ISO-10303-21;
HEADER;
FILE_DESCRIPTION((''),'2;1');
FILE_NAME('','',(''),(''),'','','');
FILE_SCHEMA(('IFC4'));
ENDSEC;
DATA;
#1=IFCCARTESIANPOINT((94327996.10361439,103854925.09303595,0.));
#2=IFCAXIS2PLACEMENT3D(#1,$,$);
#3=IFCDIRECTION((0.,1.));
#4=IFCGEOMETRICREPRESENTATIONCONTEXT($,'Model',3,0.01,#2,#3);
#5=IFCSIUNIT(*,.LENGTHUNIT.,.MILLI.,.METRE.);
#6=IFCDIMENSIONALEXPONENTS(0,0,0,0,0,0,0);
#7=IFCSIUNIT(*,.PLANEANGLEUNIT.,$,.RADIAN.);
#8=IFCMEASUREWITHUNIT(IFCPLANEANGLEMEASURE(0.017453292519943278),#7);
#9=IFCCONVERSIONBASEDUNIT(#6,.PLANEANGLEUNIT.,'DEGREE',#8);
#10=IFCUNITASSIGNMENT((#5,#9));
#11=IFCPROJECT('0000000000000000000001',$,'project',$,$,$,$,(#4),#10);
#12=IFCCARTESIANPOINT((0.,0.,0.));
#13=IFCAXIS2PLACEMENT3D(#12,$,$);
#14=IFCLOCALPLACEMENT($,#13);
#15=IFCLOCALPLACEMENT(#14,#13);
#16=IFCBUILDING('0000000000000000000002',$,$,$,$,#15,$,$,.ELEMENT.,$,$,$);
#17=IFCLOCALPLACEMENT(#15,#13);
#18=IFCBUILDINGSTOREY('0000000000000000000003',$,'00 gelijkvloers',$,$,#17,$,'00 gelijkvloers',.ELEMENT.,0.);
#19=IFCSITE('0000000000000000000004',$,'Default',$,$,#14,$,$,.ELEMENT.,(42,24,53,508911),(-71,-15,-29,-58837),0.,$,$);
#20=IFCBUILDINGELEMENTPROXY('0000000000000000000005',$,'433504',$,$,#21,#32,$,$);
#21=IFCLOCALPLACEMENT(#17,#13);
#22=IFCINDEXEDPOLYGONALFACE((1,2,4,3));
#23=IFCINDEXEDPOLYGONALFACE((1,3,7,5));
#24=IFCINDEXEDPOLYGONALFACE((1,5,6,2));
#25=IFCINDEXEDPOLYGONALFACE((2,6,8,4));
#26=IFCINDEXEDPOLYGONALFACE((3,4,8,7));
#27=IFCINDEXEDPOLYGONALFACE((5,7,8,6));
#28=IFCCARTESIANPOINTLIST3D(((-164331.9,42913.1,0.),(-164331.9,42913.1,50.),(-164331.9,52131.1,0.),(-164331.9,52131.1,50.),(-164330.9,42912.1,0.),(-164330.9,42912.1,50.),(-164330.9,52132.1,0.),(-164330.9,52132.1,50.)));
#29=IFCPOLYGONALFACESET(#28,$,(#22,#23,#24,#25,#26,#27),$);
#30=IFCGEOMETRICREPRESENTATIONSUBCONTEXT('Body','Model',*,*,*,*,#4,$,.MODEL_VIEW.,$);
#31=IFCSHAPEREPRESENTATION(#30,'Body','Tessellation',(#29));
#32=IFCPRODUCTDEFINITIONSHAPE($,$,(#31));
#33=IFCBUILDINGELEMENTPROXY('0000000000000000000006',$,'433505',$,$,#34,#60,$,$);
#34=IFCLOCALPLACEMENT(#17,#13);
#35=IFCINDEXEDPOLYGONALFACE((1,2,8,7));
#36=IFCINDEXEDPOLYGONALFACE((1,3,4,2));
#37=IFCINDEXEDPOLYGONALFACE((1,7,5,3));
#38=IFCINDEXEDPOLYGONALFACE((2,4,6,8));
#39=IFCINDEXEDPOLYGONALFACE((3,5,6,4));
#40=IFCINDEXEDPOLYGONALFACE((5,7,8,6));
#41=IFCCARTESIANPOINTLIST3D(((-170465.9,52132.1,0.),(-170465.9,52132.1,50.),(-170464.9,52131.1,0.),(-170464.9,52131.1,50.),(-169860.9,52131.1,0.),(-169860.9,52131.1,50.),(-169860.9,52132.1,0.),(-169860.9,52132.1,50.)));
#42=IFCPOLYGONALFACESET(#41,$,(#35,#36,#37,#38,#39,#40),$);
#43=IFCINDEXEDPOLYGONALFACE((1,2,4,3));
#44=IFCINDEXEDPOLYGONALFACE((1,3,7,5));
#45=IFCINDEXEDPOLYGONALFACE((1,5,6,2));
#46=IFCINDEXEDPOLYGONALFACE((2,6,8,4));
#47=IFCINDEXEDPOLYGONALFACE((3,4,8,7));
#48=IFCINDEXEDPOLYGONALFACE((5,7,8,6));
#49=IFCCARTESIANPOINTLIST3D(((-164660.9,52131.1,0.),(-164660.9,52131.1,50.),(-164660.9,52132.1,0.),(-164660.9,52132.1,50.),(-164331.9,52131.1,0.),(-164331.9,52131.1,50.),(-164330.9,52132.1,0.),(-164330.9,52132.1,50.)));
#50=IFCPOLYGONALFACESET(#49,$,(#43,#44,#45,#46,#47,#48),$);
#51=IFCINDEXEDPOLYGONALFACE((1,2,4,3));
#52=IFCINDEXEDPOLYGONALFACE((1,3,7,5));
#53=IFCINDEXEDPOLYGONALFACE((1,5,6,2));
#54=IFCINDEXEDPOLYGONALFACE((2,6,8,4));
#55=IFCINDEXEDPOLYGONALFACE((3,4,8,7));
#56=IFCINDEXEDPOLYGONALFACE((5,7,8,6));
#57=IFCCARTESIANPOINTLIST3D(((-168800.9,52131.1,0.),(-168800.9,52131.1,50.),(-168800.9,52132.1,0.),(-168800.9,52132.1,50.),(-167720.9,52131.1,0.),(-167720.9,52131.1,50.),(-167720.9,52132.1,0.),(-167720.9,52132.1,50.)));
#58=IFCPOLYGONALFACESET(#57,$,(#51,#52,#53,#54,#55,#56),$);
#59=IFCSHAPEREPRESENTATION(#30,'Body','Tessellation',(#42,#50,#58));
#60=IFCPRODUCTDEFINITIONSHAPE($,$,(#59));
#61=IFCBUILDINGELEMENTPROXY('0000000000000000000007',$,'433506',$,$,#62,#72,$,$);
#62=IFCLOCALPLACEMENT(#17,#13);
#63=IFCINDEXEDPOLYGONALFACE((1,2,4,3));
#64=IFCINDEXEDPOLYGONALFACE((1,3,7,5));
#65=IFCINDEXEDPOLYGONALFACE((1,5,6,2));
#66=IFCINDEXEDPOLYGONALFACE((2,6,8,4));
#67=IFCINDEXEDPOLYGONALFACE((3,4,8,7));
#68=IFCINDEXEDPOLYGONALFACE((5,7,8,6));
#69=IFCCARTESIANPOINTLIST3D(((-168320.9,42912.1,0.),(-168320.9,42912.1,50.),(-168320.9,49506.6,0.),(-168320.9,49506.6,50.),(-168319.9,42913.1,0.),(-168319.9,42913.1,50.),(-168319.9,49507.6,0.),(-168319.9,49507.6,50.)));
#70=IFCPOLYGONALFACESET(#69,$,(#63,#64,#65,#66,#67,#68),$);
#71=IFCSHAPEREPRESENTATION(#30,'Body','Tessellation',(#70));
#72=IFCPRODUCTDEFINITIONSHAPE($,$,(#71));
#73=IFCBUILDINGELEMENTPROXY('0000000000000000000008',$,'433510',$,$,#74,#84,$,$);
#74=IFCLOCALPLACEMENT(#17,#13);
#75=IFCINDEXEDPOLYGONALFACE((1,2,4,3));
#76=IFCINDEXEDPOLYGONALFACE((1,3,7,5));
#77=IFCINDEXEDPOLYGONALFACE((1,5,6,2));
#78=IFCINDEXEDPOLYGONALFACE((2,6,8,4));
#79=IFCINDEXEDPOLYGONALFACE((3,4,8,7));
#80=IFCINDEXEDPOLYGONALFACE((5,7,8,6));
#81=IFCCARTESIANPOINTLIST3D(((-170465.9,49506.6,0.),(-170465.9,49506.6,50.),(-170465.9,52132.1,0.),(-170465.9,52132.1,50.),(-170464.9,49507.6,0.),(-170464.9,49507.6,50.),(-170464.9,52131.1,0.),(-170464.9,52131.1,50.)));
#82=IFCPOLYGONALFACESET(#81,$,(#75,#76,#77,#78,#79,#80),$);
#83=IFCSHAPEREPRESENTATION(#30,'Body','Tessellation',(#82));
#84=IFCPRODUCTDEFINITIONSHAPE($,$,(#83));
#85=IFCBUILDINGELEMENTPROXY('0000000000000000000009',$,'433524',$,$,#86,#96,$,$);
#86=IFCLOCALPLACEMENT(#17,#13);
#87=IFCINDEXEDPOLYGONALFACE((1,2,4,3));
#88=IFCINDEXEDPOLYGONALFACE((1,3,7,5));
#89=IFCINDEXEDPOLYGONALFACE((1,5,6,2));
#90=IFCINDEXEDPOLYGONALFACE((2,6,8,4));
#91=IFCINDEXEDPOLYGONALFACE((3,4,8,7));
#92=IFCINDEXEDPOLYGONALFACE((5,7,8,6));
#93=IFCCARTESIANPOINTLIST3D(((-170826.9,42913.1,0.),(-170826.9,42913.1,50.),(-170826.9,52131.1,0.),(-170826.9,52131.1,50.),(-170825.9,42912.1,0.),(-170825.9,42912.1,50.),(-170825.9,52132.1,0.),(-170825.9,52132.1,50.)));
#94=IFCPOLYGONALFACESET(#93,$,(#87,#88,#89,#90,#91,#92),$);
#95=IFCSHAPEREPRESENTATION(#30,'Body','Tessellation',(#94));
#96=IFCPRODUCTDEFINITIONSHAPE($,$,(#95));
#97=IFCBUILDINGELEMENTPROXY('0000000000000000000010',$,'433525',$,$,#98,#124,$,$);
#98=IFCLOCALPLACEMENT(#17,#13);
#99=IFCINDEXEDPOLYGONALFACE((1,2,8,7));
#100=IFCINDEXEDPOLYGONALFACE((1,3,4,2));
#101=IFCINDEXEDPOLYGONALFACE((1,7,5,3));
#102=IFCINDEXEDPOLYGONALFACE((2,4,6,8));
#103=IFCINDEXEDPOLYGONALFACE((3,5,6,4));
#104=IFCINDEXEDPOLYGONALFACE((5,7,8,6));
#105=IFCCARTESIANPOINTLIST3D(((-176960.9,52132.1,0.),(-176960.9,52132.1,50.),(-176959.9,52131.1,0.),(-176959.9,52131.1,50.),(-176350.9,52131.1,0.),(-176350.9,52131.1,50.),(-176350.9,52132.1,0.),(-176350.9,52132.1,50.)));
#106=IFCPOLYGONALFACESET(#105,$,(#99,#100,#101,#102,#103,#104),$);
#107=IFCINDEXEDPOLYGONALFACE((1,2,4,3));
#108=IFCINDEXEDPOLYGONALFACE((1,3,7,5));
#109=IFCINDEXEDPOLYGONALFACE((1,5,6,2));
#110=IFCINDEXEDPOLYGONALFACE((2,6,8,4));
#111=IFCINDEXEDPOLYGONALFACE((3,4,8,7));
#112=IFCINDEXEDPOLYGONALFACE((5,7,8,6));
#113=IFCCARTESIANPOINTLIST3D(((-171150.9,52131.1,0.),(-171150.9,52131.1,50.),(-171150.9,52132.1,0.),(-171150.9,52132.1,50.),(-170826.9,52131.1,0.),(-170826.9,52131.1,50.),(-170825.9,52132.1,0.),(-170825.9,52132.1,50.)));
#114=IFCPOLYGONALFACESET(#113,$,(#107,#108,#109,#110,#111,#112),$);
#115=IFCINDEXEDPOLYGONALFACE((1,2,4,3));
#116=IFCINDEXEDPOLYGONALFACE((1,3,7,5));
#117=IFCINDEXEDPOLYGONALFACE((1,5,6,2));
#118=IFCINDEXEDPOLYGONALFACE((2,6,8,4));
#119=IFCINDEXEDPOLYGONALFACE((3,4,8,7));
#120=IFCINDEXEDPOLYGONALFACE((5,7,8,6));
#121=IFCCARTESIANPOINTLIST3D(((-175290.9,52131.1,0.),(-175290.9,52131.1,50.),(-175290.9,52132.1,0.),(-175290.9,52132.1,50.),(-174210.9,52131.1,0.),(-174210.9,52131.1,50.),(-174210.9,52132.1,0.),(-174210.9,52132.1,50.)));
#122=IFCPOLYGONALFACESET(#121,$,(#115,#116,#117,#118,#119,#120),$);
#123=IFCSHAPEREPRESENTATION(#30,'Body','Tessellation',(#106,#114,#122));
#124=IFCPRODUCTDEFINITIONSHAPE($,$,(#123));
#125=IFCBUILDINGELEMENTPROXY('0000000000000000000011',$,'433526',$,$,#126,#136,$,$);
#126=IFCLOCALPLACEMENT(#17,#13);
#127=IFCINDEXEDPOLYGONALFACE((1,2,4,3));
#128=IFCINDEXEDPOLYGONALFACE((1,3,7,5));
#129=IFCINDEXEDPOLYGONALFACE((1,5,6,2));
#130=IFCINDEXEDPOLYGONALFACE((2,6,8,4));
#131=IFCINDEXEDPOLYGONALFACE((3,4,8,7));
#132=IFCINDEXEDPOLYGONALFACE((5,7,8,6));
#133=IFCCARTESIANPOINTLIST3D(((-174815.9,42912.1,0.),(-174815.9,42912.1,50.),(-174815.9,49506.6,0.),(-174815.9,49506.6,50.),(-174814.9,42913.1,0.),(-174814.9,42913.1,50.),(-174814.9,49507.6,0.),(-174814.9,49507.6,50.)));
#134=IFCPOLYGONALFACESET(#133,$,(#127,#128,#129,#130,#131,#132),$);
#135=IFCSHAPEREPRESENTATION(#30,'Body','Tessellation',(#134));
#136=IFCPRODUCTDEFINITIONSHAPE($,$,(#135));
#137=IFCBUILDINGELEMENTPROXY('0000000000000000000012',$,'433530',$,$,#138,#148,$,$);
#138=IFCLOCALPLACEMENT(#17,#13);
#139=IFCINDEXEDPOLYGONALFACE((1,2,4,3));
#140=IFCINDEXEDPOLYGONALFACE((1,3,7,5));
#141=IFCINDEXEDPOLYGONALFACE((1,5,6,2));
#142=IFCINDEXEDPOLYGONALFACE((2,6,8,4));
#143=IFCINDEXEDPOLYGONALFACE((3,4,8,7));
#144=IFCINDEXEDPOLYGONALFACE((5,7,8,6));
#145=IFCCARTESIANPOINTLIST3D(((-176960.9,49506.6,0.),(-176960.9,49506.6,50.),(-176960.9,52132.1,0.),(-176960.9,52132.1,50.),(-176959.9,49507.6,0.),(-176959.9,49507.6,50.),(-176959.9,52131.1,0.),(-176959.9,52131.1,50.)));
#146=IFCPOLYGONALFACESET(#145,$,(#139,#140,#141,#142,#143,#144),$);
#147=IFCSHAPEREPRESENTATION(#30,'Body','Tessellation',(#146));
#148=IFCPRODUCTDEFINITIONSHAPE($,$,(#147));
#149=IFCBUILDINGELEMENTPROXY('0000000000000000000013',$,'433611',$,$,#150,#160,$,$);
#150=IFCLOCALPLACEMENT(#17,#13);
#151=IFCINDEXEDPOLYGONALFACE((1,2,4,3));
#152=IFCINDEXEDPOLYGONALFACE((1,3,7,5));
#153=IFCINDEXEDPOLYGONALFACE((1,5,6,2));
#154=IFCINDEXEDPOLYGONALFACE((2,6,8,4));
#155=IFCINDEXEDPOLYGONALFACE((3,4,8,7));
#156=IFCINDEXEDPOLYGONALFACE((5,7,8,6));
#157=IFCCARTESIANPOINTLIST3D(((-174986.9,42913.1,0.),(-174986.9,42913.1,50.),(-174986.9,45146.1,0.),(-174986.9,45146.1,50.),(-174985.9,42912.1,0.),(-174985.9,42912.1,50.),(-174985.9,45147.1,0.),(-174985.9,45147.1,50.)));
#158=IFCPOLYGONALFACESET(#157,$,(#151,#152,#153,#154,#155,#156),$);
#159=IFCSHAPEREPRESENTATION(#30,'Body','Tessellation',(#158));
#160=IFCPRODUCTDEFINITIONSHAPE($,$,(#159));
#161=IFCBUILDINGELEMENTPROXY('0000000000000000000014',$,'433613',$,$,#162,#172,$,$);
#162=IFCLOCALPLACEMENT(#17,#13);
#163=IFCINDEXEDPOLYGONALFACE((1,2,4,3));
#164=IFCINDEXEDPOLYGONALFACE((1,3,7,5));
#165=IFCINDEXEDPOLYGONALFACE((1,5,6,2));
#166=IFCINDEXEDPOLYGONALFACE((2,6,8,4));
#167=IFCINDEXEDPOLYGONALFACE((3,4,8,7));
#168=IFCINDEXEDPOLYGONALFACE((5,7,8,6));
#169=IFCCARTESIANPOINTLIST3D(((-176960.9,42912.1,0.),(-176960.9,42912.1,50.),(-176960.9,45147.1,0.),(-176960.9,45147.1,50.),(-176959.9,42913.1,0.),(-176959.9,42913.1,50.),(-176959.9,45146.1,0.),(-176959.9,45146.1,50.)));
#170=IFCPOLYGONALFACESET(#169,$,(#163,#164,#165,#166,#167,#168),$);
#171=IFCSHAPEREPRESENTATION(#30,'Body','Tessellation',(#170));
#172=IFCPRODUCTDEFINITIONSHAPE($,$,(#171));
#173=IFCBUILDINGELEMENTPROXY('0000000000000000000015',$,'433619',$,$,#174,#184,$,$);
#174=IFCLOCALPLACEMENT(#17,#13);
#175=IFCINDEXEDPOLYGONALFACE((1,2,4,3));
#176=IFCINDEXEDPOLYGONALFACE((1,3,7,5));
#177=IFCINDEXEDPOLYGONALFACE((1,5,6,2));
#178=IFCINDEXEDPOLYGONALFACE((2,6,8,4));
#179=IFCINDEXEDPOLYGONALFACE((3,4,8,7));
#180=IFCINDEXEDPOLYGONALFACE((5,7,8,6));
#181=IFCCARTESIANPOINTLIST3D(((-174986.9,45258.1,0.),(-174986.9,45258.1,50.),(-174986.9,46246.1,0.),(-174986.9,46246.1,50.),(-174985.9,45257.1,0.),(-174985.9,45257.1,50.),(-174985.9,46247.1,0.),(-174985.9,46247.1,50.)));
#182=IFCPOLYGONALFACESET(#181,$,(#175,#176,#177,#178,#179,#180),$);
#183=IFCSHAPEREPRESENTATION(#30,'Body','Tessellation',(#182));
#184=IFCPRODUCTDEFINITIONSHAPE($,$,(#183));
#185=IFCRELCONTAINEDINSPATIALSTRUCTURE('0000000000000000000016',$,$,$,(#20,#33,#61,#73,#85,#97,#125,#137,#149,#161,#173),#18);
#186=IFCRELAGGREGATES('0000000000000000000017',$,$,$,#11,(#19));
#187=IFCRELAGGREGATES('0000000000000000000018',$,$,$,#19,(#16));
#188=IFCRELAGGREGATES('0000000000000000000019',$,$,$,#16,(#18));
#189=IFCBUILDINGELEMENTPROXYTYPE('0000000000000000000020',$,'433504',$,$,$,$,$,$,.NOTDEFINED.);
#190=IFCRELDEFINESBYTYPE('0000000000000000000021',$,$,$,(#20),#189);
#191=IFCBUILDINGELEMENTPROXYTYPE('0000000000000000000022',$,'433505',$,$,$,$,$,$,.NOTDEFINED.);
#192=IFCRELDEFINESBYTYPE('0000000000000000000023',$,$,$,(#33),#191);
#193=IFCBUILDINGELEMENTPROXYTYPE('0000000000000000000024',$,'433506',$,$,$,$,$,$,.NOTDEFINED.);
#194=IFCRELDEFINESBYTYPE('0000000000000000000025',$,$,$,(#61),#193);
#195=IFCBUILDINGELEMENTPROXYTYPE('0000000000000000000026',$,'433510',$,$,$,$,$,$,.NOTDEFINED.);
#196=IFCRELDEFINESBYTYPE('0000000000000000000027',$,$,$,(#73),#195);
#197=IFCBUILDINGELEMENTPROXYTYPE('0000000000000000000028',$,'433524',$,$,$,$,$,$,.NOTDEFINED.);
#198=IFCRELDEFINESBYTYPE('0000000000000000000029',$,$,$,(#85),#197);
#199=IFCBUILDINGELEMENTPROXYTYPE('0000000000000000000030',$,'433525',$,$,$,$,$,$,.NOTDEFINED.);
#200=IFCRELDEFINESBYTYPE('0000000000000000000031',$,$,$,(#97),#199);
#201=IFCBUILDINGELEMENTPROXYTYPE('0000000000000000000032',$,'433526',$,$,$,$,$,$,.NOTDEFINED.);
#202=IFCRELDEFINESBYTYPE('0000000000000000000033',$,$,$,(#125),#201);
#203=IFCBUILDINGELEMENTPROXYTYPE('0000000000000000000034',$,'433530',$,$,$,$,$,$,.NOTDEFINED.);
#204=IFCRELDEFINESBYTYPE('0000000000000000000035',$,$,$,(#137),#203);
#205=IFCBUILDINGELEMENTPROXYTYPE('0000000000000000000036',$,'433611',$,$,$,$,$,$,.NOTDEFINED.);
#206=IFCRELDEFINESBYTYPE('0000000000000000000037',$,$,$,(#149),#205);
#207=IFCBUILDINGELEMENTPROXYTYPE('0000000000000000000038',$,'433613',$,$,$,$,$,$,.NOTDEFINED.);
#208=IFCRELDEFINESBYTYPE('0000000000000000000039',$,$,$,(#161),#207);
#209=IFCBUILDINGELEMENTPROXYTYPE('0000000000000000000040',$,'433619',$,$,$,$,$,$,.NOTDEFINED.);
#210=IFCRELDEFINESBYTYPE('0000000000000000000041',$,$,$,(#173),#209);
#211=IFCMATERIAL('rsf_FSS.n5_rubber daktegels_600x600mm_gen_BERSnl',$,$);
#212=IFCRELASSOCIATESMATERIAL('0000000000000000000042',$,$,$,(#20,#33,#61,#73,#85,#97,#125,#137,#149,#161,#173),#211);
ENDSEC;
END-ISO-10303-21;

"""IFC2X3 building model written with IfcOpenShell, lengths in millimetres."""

from ifc_helpers import new_model, entity, si_unit, converted_unit, direction, frame, frame_2d, origin, origin_2d_with_axis, place, context, subcontext, project, spatial, polyline, rectangle, outline, extrude, material, type_object, element, save


model = new_model("IFC2X3")

# Units and contexts
model_context = context("Model", 3, precision=0.01, world=frame((94327996.10361439, 103854925.09303595, 0.0)), true_north=direction((0.0, 1.0)))
body_context = subcontext(model_context, "Body", "Model", "MODEL_VIEW")
ifc_project = project(units=[si_unit("LENGTHUNIT", "METRE", prefix="MILLI"), converted_unit("PLANEANGLEUNIT", "DEGREE", entity("IfcPlaneAngleMeasure", 0.017453292519943278), si_unit("PLANEANGLEUNIT", "RADIAN"), dimensions=[0, 0, 0, 0, 0, 0, 0])], contexts=[model_context])

# Site, building, storey
site_placement = place(None, origin())
site = spatial("IfcSite", under=ifc_project, at=site_placement, Name="Default", CompositionType="ELEMENT", RefLatitude=(42, 24, 53, 508911), RefLongitude=(-71, -15, -29, -58837), RefElevation=0.0)
building_placement = place(site_placement, origin())
building = spatial("IfcBuilding", under=site, at=building_placement, CompositionType="ELEMENT")
storey_placement = place(building_placement, origin())
storey = spatial("IfcBuildingStorey", under=building, at=storey_placement, Name="00 gelijkvloers", LongName="00 gelijkvloers", CompositionType="ELEMENT", Elevation=0.0)

# Building element proxies
ifc_material = material(Name="rsf_FSS.n5_rubber daktegels_600x600mm_gen_BERSnl")
building_element_proxy_type_1 = type_object("IfcBuildingElementProxyType", Name="433504", PredefinedType="NOTDEFINED")
proxy_1_placement = place(storey_placement, origin())
element("IfcBuildingElementProxy", 1, at=proxy_1_placement, inside=storey, type_object=building_element_proxy_type_1, material=ifc_material, Name="433504", context=body_context, shape_type="SweptSolid", body=[
    extrude(outline(polyline([(-4609.0, -0.5), (4609.0, -0.5), (4610.0, 0.5), (-4610.0, 0.5), (-4609.0, -0.5)])), frame((-164331.4, 47522.1, 0.0), z_axis=(0.0, 0.0, 1.0), x_axis=(0.0, -1.0, 0.0)), (0.0, 0.0, 1.0), 50.0),
])
building_element_proxy_type_2 = type_object("IfcBuildingElementProxyType", Name="433505", PredefinedType="NOTDEFINED")
proxy_2_placement = place(storey_placement, origin())
element("IfcBuildingElementProxy", 2, at=proxy_2_placement, inside=storey, type_object=building_element_proxy_type_2, material=ifc_material, Name="433505", context=body_context, shape_type="SweptSolid", body=[
    extrude(outline(polyline([(-301.7, -0.5), (302.2, -0.5), (302.2, 0.5), (-302.7, 0.5), (-301.7, -0.5)])), frame((-170163.1, 52131.6, 0.0)), (0.0, 0.0, 1.0), 50.0),
    extrude(outline(polyline([(-164.8, -0.5), (164.3, -0.5), (165.3, 0.5), (-164.8, 0.5), (-164.8, -0.5)])), frame((-164496.1, 52131.6, 0.0)), (0.0, 0.0, 1.0), 50.0),
    extrude(rectangle(XDim=1080.0, YDim=1.0, at=origin_2d_with_axis()), frame((-168260.9, 52131.6, 0.0)), (0.0, 0.0, 1.0), 50.0),
])
building_element_proxy_type_3 = type_object("IfcBuildingElementProxyType", Name="433506", PredefinedType="NOTDEFINED")
proxy_3_placement = place(storey_placement, origin())
element("IfcBuildingElementProxy", 3, at=proxy_3_placement, inside=storey, type_object=building_element_proxy_type_3, material=ifc_material, Name="433506", context=body_context, shape_type="SweptSolid", body=[
    extrude(outline(polyline([(-3296.8, -0.5), (3297.8, -0.5), (3296.8, 0.5), (-3297.8, 0.5), (-3296.8, -0.5)])), frame((-168320.4, 46209.8, 0.0), z_axis=(0.0, 0.0, 1.0), x_axis=(0.0, 1.0, 0.0)), (0.0, 0.0, 1.0), 50.0),
])
building_element_proxy_type_4 = type_object("IfcBuildingElementProxyType", Name="433510", PredefinedType="NOTDEFINED")
proxy_4_placement = place(storey_placement, origin())
element("IfcBuildingElementProxy", 4, at=proxy_4_placement, inside=storey, type_object=building_element_proxy_type_4, material=ifc_material, Name="433510", context=body_context, shape_type="SweptSolid", body=[
    extrude(outline(polyline([(-1311.7, -0.5), (1311.7, -0.5), (1312.7, 0.5), (-1312.7, 0.5), (-1311.7, -0.5)])), frame((-170465.4, 50819.3, 0.0), z_axis=(0.0, 0.0, 1.0), x_axis=(0.0, 1.0, 0.0)), (0.0, 0.0, 1.0), 50.0),
])
building_element_proxy_type_5 = type_object("IfcBuildingElementProxyType", Name="433524", PredefinedType="NOTDEFINED")
proxy_5_placement = place(storey_placement, origin())
element("IfcBuildingElementProxy", 5, at=proxy_5_placement, inside=storey, type_object=building_element_proxy_type_5, material=ifc_material, Name="433524", context=body_context, shape_type="SweptSolid", body=[
    extrude(outline(polyline([(-4609.0, -0.5), (4609.0, -0.5), (4610.0, 0.5), (-4610.0, 0.5), (-4609.0, -0.5)])), frame((-170826.4, 47522.1, 0.0), z_axis=(0.0, 0.0, 1.0), x_axis=(0.0, -1.0, 0.0)), (0.0, 0.0, 1.0), 50.0),
])
building_element_proxy_type_6 = type_object("IfcBuildingElementProxyType", Name="433525", PredefinedType="NOTDEFINED")
proxy_6_placement = place(storey_placement, origin())
element("IfcBuildingElementProxy", 6, at=proxy_6_placement, inside=storey, type_object=building_element_proxy_type_6, material=ifc_material, Name="433525", context=body_context, shape_type="SweptSolid", body=[
    extrude(outline(polyline([(-304.2, -0.5), (304.7, -0.5), (304.7, 0.5), (-305.2, 0.5), (-304.2, -0.5)])), frame((-176655.6, 52131.6, 0.0)), (0.0, 0.0, 1.0), 50.0),
    extrude(outline(polyline([(-162.3, -0.5), (161.8, -0.5), (162.8, 0.5), (-162.3, 0.5), (-162.3, -0.5)])), frame((-170988.6, 52131.6, 0.0)), (0.0, 0.0, 1.0), 50.0),
    extrude(rectangle(XDim=1080.0, YDim=1.0, at=frame_2d((0.0, 0.0), x_axis=(1.0, 0.0))), frame((-174750.9, 52131.6, 0.0)), (0.0, 0.0, 1.0), 50.0),
])
building_element_proxy_type_7 = type_object("IfcBuildingElementProxyType", Name="433526", PredefinedType="NOTDEFINED")
proxy_7_placement = place(storey_placement, origin())
element("IfcBuildingElementProxy", 7, at=proxy_7_placement, inside=storey, type_object=building_element_proxy_type_7, material=ifc_material, Name="433526", context=body_context, shape_type="SweptSolid", body=[
    extrude(outline(polyline([(-3296.8, -0.5), (3297.8, -0.5), (3296.8, 0.5), (-3297.8, 0.5), (-3296.8, -0.5)])), frame((-174815.4, 46209.8, 0.0), z_axis=(0.0, 0.0, 1.0), x_axis=(0.0, 1.0, 0.0)), (0.0, 0.0, 1.0), 50.0),
])
building_element_proxy_type_8 = type_object("IfcBuildingElementProxyType", Name="433530", PredefinedType="NOTDEFINED")
proxy_8_placement = place(storey_placement, origin())
element("IfcBuildingElementProxy", 8, at=proxy_8_placement, inside=storey, type_object=building_element_proxy_type_8, material=ifc_material, Name="433530", context=body_context, shape_type="SweptSolid", body=[
    extrude(outline(polyline([(-1311.7, -0.5), (1311.7, -0.5), (1312.7, 0.5), (-1312.7, 0.5), (-1311.7, -0.5)])), frame((-176960.4, 50819.3, 0.0), z_axis=(0.0, 0.0, 1.0), x_axis=(0.0, 1.0, 0.0)), (0.0, 0.0, 1.0), 50.0),
])
building_element_proxy_type_9 = type_object("IfcBuildingElementProxyType", Name="433611", PredefinedType="NOTDEFINED")
proxy_9_placement = place(storey_placement, origin())
element("IfcBuildingElementProxy", 9, at=proxy_9_placement, inside=storey, type_object=building_element_proxy_type_9, material=ifc_material, Name="433611", context=body_context, shape_type="SweptSolid", body=[
    extrude(outline(polyline([(-1116.5, -0.5), (1116.5, -0.5), (1117.5, 0.5), (-1117.5, 0.5), (-1116.5, -0.5)])), frame((-174986.4, 44029.6, 0.0), z_axis=(0.0, 0.0, 1.0), x_axis=(0.0, -1.0, 0.0)), (0.0, 0.0, 1.0), 50.0),
])
building_element_proxy_type_10 = type_object("IfcBuildingElementProxyType", Name="433613", PredefinedType="NOTDEFINED")
proxy_10_placement = place(storey_placement, origin())
element("IfcBuildingElementProxy", 10, at=proxy_10_placement, inside=storey, type_object=building_element_proxy_type_10, material=ifc_material, Name="433613", context=body_context, shape_type="SweptSolid", body=[
    extrude(outline(polyline([(-1116.5, -0.5), (1116.5, -0.5), (1117.5, 0.5), (-1117.5, 0.5), (-1116.5, -0.5)])), frame((-176960.4, 44029.6, 0.0), z_axis=(0.0, 0.0, 1.0), x_axis=(0.0, 1.0, 0.0)), (0.0, 0.0, 1.0), 50.0),
])
building_element_proxy_type_11 = type_object("IfcBuildingElementProxyType", Name="433619", PredefinedType="NOTDEFINED")
proxy_11_placement = place(storey_placement, origin())
element("IfcBuildingElementProxy", 11, at=proxy_11_placement, inside=storey, type_object=building_element_proxy_type_11, material=ifc_material, Name="433619", context=body_context, shape_type="SweptSolid", body=[
    extrude(outline(polyline([(-494.0, -0.5), (494.0, -0.5), (495.0, 0.5), (-495.0, 0.5), (-494.0, -0.5)])), frame((-174986.4, 45752.1, 0.0), z_axis=(0.0, 0.0, 1.0), x_axis=(0.0, -1.0, 0.0)), (0.0, 0.0, 1.0), 50.0),
])

save(model, "model.ifc")
